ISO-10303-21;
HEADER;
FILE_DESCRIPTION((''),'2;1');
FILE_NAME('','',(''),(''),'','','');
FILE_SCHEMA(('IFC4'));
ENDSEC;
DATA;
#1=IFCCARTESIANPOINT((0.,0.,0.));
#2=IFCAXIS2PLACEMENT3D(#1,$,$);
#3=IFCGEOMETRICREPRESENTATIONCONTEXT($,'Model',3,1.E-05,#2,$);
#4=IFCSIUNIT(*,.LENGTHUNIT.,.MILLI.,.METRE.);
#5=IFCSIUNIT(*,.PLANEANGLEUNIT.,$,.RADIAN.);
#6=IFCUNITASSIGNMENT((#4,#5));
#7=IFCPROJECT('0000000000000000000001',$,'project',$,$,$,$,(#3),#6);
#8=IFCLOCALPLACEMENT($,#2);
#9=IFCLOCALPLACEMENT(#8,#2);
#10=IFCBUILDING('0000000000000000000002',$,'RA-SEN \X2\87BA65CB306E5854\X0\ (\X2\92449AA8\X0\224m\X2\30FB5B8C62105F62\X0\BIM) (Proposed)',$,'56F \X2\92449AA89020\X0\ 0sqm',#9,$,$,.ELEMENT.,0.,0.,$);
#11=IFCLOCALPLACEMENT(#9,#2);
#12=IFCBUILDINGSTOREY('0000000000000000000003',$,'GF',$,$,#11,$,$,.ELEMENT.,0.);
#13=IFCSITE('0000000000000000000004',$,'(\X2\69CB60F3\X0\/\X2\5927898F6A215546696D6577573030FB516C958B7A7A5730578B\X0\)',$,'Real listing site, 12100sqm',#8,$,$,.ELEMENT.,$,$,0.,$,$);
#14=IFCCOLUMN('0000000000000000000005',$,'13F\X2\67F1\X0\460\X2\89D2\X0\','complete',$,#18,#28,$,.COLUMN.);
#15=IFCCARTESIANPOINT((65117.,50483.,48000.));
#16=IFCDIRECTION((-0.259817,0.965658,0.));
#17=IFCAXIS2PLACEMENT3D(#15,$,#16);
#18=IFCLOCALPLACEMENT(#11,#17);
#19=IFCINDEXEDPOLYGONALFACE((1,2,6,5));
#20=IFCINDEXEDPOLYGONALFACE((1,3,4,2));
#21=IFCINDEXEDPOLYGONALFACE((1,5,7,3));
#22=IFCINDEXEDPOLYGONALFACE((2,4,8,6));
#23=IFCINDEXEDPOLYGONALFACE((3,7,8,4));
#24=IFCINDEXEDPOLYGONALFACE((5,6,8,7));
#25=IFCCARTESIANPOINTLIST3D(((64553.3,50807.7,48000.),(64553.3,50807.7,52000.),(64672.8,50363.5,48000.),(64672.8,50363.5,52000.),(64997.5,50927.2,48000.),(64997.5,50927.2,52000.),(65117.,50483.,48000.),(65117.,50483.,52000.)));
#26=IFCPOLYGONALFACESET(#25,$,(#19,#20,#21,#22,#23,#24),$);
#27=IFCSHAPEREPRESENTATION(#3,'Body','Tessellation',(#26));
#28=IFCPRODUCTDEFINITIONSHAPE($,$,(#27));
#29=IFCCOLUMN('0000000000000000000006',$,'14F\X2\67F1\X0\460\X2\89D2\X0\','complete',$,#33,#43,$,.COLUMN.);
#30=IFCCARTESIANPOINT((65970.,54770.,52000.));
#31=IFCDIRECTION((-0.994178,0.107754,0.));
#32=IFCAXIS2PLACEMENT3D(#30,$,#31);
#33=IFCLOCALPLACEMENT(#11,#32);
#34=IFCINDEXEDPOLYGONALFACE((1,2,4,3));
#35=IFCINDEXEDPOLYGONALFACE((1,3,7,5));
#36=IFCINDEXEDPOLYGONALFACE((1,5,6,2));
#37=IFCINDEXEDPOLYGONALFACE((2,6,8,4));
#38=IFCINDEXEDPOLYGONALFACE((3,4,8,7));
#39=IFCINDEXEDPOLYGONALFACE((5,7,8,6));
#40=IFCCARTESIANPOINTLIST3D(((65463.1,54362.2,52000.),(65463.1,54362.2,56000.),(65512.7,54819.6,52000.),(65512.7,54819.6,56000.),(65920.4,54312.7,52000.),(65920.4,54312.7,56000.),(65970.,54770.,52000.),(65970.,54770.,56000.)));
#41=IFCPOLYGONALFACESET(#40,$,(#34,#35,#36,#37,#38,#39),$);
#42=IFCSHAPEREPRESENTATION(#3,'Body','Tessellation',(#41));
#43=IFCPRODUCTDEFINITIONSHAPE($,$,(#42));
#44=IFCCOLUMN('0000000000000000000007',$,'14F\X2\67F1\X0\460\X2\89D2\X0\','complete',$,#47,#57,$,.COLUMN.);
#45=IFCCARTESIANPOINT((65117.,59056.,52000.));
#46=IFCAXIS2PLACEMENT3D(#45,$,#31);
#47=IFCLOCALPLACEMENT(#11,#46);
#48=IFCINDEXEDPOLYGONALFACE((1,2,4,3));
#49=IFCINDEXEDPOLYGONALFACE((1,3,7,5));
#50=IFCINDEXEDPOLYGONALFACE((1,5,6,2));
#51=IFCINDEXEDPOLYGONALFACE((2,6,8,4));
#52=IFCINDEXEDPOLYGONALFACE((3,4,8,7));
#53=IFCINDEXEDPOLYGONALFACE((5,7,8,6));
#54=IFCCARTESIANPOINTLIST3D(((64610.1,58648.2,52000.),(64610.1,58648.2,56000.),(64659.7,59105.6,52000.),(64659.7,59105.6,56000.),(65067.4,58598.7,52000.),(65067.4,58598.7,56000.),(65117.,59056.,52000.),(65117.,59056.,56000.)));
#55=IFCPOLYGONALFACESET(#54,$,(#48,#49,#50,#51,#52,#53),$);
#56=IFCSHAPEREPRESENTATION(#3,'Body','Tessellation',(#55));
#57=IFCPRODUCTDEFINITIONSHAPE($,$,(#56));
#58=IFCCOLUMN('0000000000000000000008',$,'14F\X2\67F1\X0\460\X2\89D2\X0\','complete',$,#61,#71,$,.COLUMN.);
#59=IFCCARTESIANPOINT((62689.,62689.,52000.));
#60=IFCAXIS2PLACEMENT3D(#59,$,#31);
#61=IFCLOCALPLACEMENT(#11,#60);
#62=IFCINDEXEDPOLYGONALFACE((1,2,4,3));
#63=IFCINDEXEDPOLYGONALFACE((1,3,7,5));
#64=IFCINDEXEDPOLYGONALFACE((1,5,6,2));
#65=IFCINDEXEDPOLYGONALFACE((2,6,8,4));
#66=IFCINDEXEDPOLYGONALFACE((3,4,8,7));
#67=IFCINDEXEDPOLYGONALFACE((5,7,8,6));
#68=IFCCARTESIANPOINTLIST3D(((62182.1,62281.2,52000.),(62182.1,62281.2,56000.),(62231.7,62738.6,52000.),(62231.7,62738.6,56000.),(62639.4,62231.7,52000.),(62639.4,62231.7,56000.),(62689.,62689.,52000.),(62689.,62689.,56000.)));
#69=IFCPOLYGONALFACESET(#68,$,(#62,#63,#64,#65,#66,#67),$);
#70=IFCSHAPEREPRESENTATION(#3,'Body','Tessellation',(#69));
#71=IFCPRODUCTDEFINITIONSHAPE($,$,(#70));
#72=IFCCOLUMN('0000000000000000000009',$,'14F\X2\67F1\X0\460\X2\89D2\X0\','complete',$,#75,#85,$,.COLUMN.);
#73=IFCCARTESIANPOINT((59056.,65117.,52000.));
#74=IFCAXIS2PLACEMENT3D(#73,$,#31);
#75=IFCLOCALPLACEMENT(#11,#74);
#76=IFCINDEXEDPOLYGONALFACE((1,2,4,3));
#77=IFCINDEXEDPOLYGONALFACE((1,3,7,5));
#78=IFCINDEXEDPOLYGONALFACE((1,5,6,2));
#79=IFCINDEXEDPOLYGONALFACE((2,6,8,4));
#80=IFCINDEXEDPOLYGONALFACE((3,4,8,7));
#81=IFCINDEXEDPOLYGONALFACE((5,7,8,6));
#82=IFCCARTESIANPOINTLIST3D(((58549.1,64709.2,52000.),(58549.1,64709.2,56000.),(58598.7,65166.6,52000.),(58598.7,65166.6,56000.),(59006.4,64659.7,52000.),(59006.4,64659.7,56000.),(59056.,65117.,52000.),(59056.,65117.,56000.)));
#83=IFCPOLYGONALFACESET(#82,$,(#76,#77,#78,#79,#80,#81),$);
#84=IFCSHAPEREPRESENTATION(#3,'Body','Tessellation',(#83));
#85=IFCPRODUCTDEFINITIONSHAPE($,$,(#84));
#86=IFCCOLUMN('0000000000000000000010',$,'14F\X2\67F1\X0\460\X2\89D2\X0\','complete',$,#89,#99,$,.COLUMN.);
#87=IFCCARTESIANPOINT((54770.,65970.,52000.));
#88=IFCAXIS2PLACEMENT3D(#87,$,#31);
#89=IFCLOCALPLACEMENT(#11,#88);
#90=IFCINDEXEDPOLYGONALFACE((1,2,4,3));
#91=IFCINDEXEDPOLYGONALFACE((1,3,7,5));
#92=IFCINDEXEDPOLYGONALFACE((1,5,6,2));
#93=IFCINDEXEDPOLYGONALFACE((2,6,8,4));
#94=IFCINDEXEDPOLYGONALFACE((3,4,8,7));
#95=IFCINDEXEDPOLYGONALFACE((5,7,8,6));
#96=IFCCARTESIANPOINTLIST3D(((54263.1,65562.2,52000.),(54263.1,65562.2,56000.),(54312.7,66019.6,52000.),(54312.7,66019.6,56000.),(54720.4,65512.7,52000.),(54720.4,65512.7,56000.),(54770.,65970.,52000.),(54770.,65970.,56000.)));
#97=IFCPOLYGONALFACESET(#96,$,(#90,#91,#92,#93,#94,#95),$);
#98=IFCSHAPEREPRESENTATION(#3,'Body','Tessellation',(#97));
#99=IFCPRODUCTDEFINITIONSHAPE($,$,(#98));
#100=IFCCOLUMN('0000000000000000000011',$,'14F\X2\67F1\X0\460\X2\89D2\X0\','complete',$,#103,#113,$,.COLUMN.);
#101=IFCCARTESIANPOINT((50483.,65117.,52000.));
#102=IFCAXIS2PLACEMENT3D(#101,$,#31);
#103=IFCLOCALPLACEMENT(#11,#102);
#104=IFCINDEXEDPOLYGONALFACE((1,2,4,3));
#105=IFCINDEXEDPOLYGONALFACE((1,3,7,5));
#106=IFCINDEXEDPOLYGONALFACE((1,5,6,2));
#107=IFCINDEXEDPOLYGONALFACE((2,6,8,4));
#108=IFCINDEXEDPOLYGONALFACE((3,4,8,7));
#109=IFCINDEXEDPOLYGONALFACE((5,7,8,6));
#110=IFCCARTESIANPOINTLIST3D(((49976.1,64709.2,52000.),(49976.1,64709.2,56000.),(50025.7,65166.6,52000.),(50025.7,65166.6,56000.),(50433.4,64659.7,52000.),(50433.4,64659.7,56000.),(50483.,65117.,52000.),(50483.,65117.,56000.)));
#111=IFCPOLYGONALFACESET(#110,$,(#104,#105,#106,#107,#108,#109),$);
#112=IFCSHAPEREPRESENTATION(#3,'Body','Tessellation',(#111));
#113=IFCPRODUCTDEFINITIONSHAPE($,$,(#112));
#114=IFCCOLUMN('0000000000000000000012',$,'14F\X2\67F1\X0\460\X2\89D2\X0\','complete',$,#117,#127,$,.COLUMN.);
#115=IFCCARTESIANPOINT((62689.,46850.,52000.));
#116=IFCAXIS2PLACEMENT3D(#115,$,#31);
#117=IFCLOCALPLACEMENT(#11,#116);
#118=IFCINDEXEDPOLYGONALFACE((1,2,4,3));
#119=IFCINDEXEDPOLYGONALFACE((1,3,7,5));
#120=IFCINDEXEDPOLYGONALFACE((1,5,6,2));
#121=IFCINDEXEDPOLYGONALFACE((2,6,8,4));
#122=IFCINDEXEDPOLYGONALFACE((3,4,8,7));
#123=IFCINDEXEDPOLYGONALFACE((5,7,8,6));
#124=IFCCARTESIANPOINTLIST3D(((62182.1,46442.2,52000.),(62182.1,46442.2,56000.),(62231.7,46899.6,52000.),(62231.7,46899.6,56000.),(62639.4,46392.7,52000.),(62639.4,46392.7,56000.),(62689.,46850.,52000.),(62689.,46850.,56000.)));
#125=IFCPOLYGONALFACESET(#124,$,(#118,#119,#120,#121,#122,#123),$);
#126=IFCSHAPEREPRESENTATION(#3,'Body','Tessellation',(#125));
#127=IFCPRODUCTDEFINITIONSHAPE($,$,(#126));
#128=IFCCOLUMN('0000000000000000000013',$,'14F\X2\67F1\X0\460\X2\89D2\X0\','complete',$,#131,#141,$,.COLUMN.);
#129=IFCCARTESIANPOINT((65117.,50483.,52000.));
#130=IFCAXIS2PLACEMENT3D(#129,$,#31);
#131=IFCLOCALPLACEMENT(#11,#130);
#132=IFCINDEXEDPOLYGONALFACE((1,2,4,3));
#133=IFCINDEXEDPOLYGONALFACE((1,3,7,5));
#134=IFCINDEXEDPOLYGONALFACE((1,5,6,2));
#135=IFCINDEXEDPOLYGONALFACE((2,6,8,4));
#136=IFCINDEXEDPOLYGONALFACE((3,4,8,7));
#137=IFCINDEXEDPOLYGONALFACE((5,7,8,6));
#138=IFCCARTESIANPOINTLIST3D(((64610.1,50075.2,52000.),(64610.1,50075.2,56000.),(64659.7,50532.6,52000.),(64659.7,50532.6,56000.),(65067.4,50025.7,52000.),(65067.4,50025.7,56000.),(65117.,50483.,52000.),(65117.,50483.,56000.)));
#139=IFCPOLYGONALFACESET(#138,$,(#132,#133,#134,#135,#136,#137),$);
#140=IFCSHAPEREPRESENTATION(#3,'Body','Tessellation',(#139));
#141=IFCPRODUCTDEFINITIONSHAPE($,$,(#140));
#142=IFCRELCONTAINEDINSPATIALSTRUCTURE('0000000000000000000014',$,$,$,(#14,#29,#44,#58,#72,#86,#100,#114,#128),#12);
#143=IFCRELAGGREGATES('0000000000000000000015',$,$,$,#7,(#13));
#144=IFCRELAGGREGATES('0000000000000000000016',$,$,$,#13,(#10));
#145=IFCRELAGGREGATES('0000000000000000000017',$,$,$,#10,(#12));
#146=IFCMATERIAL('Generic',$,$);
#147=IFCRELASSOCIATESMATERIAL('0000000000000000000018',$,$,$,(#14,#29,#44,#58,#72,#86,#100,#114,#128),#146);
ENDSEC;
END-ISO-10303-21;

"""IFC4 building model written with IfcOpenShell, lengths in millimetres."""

from ifc_helpers import new_model, si_unit, frame, frame_2d, origin, place, context, project, spatial, rectangle, extrude, material, element, save


model = new_model("IFC4")

# Units and contexts
model_context = context("Model", 3, precision=1e-05, world=origin())
ifc_project = project(units=[si_unit("LENGTHUNIT", "METRE", prefix="MILLI"), si_unit("PLANEANGLEUNIT", "RADIAN")], contexts=[model_context])

# Site, building, storey
site_placement = place(None, origin())
site = spatial("IfcSite", under=ifc_project, at=site_placement, Name="(構想/大規模商業敷地・公開空地型)", ObjectType="Real listing site, 12100sqm", CompositionType="ELEMENT", RefElevation=0.0)
building_placement = place(site_placement, origin())
building = spatial("IfcBuilding", under=site, at=building_placement, Name="RA-SEN 螺旋の塔 (鉄骨224m・完成形BIM) (Proposed)", ObjectType="56F 鉄骨造 0sqm", CompositionType="ELEMENT", ElevationOfRefHeight=0.0, ElevationOfTerrain=0.0)
storey_placement = place(building_placement, origin())
storey = spatial("IfcBuildingStorey", under=building, at=storey_placement, Name="GF", CompositionType="ELEMENT", Elevation=0.0)

# Columns
ifc_material = material(Name="Generic")
column_1_placement = place(storey_placement, frame((65117.0, 50483.0, 48000.0), x_axis=(-0.259817, 0.965658, 0.0)))
element("IfcColumn", 1, at=column_1_placement, inside=storey, material=ifc_material, Name="13F柱460角", Description="complete", PredefinedType="COLUMN", context=model_context, shape_type="SweptSolid", body=[
    extrude(rectangle(XDim=460.0, YDim=460.0, at=frame_2d((230.0, 230.0))), frame((65117.0, 50483.0, 48000.0), x_axis=(-0.259817, 0.965658, 0.0)), (0.0, 0.0, 1.0), 4000.0),
])
column_2_placement = place(storey_placement, frame((65970.0, 54770.0, 52000.0), x_axis=(-0.994178, 0.107754, 0.0)))
element("IfcColumn", 2, at=column_2_placement, inside=storey, material=ifc_material, Name="14F柱460角", Description="complete", PredefinedType="COLUMN", context=model_context, shape_type="SweptSolid", body=[
    extrude(rectangle(XDim=460.0, YDim=460.0, at=frame_2d((230.0, 230.0))), frame((65970.0, 54770.0, 52000.0), x_axis=(-0.994178, 0.107754, 0.0)), (0.0, 0.0, 1.0), 4000.0),
])
column_3_placement = place(storey_placement, frame((65117.0, 59056.0, 52000.0), x_axis=(-0.994178, 0.107754, 0.0)))
element("IfcColumn", 3, at=column_3_placement, inside=storey, material=ifc_material, Name="14F柱460角", Description="complete", PredefinedType="COLUMN", context=model_context, shape_type="SweptSolid", body=[
    extrude(rectangle(XDim=460.0, YDim=460.0, at=frame_2d((230.0, 230.0))), frame((65117.0, 59056.0, 52000.0), x_axis=(-0.994178, 0.107754, 0.0)), (0.0, 0.0, 1.0), 4000.0),
])
column_4_placement = place(storey_placement, frame((62689.0, 62689.0, 52000.0), x_axis=(-0.994178, 0.107754, 0.0)))
element("IfcColumn", 4, at=column_4_placement, inside=storey, material=ifc_material, Name="14F柱460角", Description="complete", PredefinedType="COLUMN", context=model_context, shape_type="SweptSolid", body=[
    extrude(rectangle(XDim=460.0, YDim=460.0, at=frame_2d((230.0, 230.0))), frame((62689.0, 62689.0, 52000.0), x_axis=(-0.994178, 0.107754, 0.0)), (0.0, 0.0, 1.0), 4000.0),
])
column_5_placement = place(storey_placement, frame((59056.0, 65117.0, 52000.0), x_axis=(-0.994178, 0.107754, 0.0)))
element("IfcColumn", 5, at=column_5_placement, inside=storey, material=ifc_material, Name="14F柱460角", Description="complete", PredefinedType="COLUMN", context=model_context, shape_type="SweptSolid", body=[
    extrude(rectangle(XDim=460.0, YDim=460.0, at=frame_2d((230.0, 230.0))), frame((59056.0, 65117.0, 52000.0), x_axis=(-0.994178, 0.107754, 0.0)), (0.0, 0.0, 1.0), 4000.0),
])
column_6_placement = place(storey_placement, frame((54770.0, 65970.0, 52000.0), x_axis=(-0.994178, 0.107754, 0.0)))
element("IfcColumn", 6, at=column_6_placement, inside=storey, material=ifc_material, Name="14F柱460角", Description="complete", PredefinedType="COLUMN", context=model_context, shape_type="SweptSolid", body=[
    extrude(rectangle(XDim=460.0, YDim=460.0, at=frame_2d((230.0, 230.0))), frame((54770.0, 65970.0, 52000.0), x_axis=(-0.994178, 0.107754, 0.0)), (0.0, 0.0, 1.0), 4000.0),
])
column_7_placement = place(storey_placement, frame((50483.0, 65117.0, 52000.0), x_axis=(-0.994178, 0.107754, 0.0)))
element("IfcColumn", 7, at=column_7_placement, inside=storey, material=ifc_material, Name="14F柱460角", Description="complete", PredefinedType="COLUMN", context=model_context, shape_type="SweptSolid", body=[
    extrude(rectangle(XDim=460.0, YDim=460.0, at=frame_2d((230.0, 230.0))), frame((50483.0, 65117.0, 52000.0), x_axis=(-0.994178, 0.107754, 0.0)), (0.0, 0.0, 1.0), 4000.0),
])
column_8_placement = place(storey_placement, frame((62689.0, 46850.0, 52000.0), x_axis=(-0.994178, 0.107754, 0.0)))
element("IfcColumn", 8, at=column_8_placement, inside=storey, material=ifc_material, Name="14F柱460角", Description="complete", PredefinedType="COLUMN", context=model_context, shape_type="SweptSolid", body=[
    extrude(rectangle(XDim=460.0, YDim=460.0, at=frame_2d((230.0, 230.0))), frame((62689.0, 46850.0, 52000.0), x_axis=(-0.994178, 0.107754, 0.0)), (0.0, 0.0, 1.0), 4000.0),
])
column_9_placement = place(storey_placement, frame((65117.0, 50483.0, 52000.0), x_axis=(-0.994178, 0.107754, 0.0)))
element("IfcColumn", 9, at=column_9_placement, inside=storey, material=ifc_material, Name="14F柱460角", Description="complete", PredefinedType="COLUMN", context=model_context, shape_type="SweptSolid", body=[
    extrude(rectangle(XDim=460.0, YDim=460.0, at=frame_2d((230.0, 230.0))), frame((65117.0, 50483.0, 52000.0), x_axis=(-0.994178, 0.107754, 0.0)), (0.0, 0.0, 1.0), 4000.0),
])

save(model, "model.ifc")
